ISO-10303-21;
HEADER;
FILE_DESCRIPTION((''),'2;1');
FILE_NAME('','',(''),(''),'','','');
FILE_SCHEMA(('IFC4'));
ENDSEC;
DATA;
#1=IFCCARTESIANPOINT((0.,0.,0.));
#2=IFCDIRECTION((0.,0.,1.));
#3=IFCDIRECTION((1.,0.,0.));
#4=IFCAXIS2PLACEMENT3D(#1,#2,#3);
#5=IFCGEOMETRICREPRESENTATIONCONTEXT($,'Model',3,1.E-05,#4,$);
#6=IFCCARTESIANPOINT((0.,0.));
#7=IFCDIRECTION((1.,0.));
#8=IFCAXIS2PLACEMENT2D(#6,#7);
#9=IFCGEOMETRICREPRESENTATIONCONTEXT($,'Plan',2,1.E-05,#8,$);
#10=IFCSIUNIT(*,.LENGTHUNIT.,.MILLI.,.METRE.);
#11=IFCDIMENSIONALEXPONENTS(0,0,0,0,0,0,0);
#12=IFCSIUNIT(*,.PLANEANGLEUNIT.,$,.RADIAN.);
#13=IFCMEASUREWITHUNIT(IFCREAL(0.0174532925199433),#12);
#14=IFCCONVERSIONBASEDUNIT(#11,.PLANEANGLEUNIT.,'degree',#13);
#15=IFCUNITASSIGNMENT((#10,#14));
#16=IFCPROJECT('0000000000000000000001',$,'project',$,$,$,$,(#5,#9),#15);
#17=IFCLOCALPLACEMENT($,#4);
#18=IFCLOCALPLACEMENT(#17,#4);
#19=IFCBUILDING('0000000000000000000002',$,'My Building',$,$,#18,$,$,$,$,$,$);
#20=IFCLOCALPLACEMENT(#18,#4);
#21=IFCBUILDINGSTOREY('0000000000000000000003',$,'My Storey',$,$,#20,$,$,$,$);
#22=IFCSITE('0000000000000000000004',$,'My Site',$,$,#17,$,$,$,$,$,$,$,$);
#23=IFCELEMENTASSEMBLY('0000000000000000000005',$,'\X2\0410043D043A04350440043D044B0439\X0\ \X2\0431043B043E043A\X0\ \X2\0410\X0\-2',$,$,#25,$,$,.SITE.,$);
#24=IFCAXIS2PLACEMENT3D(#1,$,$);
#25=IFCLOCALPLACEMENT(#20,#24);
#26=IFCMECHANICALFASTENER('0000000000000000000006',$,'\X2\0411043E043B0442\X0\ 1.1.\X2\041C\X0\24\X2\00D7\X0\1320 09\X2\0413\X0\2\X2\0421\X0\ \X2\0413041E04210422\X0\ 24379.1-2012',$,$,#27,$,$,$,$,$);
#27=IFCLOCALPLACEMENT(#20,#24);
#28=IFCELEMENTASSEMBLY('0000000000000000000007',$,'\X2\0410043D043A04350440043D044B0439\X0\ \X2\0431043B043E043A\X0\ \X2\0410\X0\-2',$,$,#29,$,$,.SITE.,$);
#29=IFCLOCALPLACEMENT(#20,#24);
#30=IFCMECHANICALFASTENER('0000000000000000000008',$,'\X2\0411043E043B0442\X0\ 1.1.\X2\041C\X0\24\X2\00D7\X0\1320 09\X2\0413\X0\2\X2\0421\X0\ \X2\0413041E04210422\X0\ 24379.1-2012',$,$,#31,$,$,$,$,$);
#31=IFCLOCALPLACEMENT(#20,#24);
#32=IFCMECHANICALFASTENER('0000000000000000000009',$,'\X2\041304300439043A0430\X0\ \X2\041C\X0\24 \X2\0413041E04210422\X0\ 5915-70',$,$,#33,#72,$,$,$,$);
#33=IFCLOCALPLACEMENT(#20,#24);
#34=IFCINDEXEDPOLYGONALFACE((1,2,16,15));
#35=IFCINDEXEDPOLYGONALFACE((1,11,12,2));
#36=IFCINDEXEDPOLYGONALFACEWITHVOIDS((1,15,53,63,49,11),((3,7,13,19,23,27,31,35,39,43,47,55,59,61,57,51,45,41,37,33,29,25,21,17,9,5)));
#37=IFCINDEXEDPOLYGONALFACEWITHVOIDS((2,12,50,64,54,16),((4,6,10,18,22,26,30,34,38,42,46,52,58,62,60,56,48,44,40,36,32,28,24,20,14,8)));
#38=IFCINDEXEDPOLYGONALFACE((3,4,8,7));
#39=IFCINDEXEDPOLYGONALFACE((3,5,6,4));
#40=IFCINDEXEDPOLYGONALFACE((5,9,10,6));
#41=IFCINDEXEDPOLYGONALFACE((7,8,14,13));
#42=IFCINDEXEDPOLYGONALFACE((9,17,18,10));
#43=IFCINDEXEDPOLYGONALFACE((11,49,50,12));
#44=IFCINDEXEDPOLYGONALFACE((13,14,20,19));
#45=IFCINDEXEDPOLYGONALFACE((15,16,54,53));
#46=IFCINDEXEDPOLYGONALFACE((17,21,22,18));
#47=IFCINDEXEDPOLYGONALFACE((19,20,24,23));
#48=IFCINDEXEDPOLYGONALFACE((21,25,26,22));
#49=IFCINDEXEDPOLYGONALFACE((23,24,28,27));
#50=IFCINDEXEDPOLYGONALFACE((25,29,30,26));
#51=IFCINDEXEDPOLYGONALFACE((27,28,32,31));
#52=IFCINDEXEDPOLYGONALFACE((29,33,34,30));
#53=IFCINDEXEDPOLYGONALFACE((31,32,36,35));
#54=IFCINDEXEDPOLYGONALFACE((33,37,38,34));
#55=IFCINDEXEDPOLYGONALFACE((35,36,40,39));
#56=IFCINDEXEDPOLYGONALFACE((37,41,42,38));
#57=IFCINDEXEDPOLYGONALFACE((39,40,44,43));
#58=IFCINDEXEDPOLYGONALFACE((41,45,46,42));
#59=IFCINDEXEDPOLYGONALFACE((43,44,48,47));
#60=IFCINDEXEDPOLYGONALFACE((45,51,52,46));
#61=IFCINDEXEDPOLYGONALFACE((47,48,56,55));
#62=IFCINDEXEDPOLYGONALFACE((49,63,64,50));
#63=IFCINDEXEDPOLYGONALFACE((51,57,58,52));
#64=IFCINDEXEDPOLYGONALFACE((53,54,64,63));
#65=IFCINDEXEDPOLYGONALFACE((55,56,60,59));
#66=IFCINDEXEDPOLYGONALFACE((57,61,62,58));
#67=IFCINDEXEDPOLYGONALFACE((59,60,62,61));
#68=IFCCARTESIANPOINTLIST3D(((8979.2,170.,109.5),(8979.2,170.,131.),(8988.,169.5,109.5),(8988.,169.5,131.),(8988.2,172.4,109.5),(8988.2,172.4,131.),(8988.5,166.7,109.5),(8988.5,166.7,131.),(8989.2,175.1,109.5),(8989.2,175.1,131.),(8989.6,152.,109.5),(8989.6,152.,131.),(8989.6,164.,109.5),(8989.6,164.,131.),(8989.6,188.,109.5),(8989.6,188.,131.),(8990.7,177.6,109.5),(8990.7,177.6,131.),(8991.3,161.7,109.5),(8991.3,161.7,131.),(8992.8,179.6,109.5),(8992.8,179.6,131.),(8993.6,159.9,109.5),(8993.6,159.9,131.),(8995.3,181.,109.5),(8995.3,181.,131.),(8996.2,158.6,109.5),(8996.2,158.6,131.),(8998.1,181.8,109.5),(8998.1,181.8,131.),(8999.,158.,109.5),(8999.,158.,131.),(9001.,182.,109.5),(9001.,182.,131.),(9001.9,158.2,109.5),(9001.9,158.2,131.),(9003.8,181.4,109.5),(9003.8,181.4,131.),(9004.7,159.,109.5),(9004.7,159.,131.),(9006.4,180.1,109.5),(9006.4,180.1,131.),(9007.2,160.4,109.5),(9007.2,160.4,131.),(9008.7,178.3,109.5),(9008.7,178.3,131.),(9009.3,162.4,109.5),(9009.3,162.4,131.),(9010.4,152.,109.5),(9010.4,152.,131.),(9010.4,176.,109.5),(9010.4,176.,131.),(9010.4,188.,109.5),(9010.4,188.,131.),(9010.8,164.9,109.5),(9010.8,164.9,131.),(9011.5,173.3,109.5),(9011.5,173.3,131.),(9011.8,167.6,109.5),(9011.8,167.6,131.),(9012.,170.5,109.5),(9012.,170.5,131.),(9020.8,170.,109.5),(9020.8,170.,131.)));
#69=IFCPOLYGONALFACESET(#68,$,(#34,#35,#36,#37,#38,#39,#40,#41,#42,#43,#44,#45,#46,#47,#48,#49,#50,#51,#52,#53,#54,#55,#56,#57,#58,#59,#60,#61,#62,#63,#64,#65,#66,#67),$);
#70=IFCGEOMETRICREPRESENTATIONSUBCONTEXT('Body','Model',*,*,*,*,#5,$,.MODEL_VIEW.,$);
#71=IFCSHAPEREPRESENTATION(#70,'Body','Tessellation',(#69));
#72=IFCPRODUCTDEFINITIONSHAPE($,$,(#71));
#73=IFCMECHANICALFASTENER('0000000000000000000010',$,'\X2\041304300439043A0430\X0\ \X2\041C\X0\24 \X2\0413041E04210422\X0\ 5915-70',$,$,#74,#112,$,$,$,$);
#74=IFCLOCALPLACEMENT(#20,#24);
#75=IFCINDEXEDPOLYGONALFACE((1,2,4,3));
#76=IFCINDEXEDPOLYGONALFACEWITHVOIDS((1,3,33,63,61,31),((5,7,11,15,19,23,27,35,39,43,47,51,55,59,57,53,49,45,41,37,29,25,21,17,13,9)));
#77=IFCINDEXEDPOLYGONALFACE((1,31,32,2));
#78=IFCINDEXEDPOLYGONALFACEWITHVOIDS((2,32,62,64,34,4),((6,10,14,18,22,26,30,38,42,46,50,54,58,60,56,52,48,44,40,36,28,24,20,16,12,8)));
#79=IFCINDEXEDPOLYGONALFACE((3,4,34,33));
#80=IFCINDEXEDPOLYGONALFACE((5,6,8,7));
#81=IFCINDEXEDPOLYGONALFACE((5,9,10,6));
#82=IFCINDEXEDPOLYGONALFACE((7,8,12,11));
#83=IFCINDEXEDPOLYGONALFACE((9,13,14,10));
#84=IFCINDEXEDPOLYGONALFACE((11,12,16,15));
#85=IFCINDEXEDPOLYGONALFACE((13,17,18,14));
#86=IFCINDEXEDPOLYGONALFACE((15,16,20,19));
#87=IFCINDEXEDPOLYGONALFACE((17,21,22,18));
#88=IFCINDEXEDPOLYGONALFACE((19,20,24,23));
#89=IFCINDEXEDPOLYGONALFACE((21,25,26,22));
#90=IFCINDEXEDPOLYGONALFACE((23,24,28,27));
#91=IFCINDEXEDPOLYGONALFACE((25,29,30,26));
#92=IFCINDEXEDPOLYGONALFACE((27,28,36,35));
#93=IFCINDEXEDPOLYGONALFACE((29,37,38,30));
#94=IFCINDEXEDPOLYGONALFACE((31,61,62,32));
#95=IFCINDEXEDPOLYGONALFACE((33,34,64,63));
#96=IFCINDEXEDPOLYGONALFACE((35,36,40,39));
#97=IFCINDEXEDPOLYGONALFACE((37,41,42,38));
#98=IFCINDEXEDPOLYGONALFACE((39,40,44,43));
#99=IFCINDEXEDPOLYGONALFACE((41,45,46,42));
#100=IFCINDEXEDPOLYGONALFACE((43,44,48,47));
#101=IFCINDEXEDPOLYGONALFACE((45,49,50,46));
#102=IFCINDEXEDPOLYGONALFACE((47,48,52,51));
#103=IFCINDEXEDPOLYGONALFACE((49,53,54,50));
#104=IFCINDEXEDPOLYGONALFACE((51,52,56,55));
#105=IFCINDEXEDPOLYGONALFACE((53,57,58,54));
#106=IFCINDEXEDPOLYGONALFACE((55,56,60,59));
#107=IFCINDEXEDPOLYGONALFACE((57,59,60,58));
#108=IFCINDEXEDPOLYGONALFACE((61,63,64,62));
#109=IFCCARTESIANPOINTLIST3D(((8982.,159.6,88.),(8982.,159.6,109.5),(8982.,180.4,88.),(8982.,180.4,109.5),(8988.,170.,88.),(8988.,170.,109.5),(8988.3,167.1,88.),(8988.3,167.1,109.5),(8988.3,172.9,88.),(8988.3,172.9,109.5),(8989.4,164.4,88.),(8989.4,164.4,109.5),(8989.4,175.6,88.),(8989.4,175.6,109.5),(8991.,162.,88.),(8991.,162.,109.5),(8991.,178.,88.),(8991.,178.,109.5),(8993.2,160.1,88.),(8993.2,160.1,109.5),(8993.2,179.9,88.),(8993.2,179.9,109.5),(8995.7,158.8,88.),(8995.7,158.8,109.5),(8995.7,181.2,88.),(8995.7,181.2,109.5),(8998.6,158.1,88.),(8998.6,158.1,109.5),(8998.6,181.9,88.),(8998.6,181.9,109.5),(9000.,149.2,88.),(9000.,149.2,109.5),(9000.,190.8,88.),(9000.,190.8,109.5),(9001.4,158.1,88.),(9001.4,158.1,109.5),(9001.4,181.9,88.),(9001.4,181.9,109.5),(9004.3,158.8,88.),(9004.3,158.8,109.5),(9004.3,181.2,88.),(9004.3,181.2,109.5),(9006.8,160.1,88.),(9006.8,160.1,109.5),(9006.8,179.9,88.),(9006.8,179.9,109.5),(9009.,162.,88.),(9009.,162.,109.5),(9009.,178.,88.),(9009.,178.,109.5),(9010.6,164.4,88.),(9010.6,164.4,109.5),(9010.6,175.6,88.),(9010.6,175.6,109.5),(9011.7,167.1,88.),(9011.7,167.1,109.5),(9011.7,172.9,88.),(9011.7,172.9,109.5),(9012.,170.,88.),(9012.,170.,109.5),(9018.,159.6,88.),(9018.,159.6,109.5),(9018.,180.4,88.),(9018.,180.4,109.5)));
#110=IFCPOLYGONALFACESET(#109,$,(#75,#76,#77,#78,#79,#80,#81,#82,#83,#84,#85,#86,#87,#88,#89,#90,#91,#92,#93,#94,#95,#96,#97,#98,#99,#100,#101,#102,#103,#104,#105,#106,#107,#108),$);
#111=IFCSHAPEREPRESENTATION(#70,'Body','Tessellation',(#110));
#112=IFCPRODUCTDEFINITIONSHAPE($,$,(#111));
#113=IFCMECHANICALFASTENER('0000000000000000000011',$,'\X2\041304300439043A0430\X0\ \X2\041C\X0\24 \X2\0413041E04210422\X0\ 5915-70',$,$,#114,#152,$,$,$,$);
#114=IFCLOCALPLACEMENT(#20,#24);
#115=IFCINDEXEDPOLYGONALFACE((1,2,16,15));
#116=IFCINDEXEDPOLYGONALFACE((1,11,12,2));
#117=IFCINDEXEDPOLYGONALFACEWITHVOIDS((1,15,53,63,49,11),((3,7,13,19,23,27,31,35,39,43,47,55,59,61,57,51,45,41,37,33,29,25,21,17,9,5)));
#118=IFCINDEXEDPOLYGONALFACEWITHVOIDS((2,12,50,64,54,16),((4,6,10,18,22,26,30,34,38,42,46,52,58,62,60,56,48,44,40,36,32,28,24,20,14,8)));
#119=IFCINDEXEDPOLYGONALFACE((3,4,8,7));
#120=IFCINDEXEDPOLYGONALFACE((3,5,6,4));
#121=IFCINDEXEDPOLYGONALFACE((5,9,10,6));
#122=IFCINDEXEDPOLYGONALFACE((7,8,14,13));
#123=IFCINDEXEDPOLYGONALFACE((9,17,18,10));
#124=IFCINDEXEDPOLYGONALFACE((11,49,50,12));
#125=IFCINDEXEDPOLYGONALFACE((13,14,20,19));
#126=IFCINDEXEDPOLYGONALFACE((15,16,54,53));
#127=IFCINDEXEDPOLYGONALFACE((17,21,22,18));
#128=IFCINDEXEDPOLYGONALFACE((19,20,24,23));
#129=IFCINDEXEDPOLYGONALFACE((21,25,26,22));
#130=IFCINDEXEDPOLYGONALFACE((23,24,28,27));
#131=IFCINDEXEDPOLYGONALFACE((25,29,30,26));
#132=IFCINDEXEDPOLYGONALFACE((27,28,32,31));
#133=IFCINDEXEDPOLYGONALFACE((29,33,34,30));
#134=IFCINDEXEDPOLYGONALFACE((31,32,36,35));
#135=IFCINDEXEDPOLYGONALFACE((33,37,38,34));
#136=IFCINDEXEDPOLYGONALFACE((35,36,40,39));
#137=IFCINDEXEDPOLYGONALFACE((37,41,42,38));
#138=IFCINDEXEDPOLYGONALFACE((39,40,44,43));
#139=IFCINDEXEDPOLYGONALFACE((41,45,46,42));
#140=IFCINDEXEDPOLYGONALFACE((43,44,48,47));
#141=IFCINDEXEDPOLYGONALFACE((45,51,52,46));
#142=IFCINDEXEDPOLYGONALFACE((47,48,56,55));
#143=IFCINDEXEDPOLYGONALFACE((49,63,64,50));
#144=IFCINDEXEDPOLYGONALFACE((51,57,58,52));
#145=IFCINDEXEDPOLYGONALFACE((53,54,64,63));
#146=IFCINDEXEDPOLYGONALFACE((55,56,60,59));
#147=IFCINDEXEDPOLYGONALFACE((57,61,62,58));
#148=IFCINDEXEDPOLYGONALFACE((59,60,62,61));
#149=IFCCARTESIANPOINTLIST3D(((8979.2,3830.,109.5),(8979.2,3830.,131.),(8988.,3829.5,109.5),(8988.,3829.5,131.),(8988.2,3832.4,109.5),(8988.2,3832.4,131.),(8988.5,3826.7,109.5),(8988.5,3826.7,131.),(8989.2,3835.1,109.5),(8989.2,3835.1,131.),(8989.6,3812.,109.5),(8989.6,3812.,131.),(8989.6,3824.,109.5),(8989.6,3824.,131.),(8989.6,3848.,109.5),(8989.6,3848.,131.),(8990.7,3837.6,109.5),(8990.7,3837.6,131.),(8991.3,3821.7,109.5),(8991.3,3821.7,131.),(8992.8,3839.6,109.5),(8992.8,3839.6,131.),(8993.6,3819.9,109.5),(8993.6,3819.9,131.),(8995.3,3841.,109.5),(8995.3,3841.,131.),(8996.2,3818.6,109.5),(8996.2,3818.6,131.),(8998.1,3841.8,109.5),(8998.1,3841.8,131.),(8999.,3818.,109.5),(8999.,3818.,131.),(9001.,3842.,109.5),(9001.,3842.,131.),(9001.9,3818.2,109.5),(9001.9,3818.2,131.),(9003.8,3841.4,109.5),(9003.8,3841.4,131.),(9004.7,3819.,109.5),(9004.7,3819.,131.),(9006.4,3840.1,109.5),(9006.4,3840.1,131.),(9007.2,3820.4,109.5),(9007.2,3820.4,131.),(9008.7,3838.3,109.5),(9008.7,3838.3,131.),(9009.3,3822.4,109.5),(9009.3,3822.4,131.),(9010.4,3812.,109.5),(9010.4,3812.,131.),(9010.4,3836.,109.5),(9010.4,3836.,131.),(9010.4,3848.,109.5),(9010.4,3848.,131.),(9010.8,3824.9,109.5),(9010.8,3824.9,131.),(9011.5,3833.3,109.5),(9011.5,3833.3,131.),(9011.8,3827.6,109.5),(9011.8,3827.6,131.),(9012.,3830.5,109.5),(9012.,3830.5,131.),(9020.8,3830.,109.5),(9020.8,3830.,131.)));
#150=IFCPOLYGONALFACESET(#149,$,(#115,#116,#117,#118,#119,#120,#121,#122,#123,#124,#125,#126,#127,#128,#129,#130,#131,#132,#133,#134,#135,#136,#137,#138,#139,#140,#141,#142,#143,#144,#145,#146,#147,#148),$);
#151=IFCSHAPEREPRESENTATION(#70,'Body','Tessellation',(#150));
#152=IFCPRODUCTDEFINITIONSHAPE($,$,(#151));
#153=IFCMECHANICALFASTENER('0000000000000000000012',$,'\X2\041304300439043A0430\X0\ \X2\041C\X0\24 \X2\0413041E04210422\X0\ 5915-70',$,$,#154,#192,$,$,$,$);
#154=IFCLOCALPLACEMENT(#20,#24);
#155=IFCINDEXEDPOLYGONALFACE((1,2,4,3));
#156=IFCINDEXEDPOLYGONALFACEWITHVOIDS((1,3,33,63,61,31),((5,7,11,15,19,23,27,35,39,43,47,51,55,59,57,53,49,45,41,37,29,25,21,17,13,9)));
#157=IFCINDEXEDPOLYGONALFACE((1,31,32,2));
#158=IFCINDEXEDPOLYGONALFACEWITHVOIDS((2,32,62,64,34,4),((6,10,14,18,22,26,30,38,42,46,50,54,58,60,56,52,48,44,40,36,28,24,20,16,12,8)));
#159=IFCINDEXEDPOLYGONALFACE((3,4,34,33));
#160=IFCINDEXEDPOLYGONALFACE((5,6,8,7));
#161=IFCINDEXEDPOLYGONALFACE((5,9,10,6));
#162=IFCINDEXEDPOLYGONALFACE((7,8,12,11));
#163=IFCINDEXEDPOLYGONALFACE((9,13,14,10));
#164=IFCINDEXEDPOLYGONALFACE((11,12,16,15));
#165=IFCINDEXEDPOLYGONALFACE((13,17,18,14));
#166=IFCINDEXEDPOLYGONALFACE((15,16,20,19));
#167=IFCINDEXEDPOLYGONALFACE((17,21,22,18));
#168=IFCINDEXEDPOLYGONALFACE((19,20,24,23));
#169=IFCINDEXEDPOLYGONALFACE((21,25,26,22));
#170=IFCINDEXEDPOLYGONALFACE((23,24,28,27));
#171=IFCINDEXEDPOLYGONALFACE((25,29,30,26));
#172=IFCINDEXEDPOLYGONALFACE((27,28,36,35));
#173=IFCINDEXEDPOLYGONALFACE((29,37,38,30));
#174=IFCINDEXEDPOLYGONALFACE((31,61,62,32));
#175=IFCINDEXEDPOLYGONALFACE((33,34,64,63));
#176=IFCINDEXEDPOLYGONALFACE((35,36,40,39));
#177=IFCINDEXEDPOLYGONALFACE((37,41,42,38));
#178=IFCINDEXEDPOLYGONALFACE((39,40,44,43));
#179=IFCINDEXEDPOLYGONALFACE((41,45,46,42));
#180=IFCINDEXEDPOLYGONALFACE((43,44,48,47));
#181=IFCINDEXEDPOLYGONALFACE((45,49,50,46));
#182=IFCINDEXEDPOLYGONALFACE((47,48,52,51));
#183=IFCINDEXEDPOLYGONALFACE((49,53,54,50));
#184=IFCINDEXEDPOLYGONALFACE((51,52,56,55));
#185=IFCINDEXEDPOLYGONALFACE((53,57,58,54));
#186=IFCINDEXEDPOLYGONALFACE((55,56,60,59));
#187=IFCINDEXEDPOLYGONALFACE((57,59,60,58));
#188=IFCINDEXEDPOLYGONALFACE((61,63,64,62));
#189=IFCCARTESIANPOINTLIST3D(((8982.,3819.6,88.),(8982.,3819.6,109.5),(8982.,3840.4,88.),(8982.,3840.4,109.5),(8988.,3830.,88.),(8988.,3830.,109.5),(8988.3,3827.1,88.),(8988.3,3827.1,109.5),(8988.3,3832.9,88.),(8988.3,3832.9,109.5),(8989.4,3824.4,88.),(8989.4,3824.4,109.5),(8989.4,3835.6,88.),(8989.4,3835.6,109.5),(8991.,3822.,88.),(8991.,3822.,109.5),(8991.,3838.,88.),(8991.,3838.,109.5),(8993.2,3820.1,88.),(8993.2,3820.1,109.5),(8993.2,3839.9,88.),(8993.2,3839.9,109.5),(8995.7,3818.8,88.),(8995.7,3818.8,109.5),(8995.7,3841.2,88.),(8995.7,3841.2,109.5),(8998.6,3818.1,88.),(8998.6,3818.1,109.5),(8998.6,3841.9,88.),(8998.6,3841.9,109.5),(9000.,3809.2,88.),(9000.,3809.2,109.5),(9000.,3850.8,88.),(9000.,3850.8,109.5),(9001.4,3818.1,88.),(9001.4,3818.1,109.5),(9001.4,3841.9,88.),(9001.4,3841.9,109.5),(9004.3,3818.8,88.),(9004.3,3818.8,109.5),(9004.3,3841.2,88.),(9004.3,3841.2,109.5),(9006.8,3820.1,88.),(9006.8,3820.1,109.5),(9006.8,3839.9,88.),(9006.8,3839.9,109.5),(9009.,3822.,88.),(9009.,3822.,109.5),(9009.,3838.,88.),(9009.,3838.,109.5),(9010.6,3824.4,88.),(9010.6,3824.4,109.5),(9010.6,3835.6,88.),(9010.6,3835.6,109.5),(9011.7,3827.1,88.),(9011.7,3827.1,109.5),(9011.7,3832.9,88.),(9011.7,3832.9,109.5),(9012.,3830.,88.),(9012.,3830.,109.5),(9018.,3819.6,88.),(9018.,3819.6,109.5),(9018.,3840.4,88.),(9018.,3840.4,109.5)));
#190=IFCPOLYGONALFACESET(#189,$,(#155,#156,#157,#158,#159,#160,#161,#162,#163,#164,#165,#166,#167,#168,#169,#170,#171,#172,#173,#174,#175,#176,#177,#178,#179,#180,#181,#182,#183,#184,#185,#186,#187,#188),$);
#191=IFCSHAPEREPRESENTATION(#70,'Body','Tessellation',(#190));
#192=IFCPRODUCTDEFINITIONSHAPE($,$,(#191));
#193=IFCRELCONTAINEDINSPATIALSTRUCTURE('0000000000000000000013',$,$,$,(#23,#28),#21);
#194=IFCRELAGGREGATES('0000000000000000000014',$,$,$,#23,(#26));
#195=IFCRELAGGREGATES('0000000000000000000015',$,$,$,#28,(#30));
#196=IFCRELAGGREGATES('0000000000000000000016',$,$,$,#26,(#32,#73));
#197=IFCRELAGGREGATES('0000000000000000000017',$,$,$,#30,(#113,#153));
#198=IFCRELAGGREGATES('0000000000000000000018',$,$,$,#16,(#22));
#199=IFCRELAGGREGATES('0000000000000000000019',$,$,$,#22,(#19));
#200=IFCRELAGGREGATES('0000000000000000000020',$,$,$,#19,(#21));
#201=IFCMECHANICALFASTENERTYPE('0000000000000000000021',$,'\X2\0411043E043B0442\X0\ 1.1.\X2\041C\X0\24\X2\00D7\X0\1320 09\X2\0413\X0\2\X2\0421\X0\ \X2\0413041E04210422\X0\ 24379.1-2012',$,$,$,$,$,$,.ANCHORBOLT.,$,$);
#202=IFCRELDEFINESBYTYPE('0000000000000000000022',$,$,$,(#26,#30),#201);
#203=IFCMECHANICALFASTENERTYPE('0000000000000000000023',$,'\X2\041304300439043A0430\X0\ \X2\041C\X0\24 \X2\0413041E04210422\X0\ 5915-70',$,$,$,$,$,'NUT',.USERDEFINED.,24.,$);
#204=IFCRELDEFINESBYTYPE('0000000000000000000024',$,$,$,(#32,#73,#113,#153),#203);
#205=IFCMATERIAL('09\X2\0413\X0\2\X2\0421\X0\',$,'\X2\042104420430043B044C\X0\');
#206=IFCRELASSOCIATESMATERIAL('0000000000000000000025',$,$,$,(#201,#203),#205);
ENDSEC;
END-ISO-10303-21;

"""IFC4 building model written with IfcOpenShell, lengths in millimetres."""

from ifc_helpers import new_model, entity, si_unit, converted_unit, frame, origin_with_axes, origin_2d_with_axis, place, context, subcontext, project, spatial, polyline, outline, extrude, source, transform, mapped, material, type_object, type_shapes, element, aggregate, save


model = new_model("IFC4")

# Units and contexts
model_context = context("Model", 3, precision=1e-05, world=origin_with_axes())
plan_context = context("Plan", 2, precision=1e-05, world=origin_2d_with_axis())
body_context = subcontext(model_context, "Body", "Model", "MODEL_VIEW")
ifc_project = project(units=[si_unit("LENGTHUNIT", "METRE", prefix="MILLI"), converted_unit("PLANEANGLEUNIT", "degree", entity("IfcReal", 0.0174532925199433), si_unit("PLANEANGLEUNIT", "RADIAN"), dimensions=[0, 0, 0, 0, 0, 0, 0])], contexts=[model_context, plan_context])

# Site, building, storey
site_placement = place(None, origin_with_axes())
site = spatial("IfcSite", under=ifc_project, at=site_placement, Name="My Site")
building_placement = place(site_placement, origin_with_axes())
building = spatial("IfcBuilding", under=site, at=building_placement, Name="My Building")
storey_placement = place(building_placement, origin_with_axes())
storey = spatial("IfcBuildingStorey", under=building, at=storey_placement, Name="My Storey")

# Element assemblies, mechanical fasteners
ifc_material_1 = material(Name="09Г2С", Category="Сталь")
mechanical_fastener_type_1 = type_object("IfcMechanicalFastenerType", Name="Болт 1.1.М24×1320 09Г2С ГОСТ 24379.1-2012", PredefinedType="ANCHORBOLT", material=ifc_material_1)
assembly_1_placement = place(storey_placement, frame((9000.0, 0.0, 0.0), z_axis=(0.0, 0.0, 1.0), x_axis=(1.0, 0.0, 0.0)))
assembly_1 = element("IfcElementAssembly", 1, at=assembly_1_placement, inside=storey, Name="Анкерный блок А-2", AssemblyPlace="SITE")
mechanical_fastener_1_placement = place(assembly_1_placement, frame((0.0, 170.0, 0.0), z_axis=(0.0, 0.0, 1.0), x_axis=(-1.0, 0.0, 0.0)))
mechanical_fastener_1 = element("IfcMechanicalFastener", 2, at=mechanical_fastener_1_placement, type_object=mechanical_fastener_type_1, Name="Болт 1.1.М24×1320 09Г2С ГОСТ 24379.1-2012")
aggregate(assembly_1, [mechanical_fastener_1])
assembly_2_placement = place(storey_placement, frame((9000.0, 4000.0, 0.0), z_axis=(0.0, 0.0, 1.0), x_axis=(1.0, 0.0, 0.0)))
assembly_2 = element("IfcElementAssembly", 3, at=assembly_2_placement, inside=storey, Name="Анкерный блок А-2", AssemblyPlace="SITE")
mechanical_fastener_2_placement = place(assembly_2_placement, frame((0.0, -170.0, 0.0), z_axis=(0.0, 0.0, 1.0), x_axis=(1.0, 0.0, 0.0)))
mechanical_fastener_2 = element("IfcMechanicalFastener", 4, at=mechanical_fastener_2_placement, type_object=mechanical_fastener_type_1, Name="Болт 1.1.М24×1320 09Г2С ГОСТ 24379.1-2012")
aggregate(assembly_2, [mechanical_fastener_2])
mechanical_fastener_type_2 = type_object("IfcMechanicalFastenerType", Name="Гайка М24 ГОСТ 5915-70", ElementType="NUT", NominalDiameter=24.0, PredefinedType="USERDEFINED", material=ifc_material_1)
shared_shape_1 = source(origin_with_axes(), body_context, "Body", "SweptSolid", [
    extrude(outline(polyline([(-10.4, -18.0), (10.4, -18.0), (20.8, 0.0), (10.4, 18.0), (-10.4, 18.0), (-20.8, 0.0), (-10.4, -18.0)]), holes=[polyline([(-8.0, 9.0), (-5.6, 10.6), (-2.9, 11.7), (0.0, 12.0), (2.9, 11.7), (5.6, 10.6), (8.0, 9.0), (9.9, 6.8), (11.2, 4.3), (11.9, 1.4), (11.9, -1.4), (11.2, -4.3), (9.9, -6.8), (8.0, -9.0), (5.6, -10.6), (2.9, -11.7), (0.0, -12.0), (-2.9, -11.7), (-5.6, -10.6), (-8.0, -9.0), (-9.9, -6.8), (-11.2, -4.3), (-11.9, -1.4), (-11.9, 1.4), (-11.2, 4.3), (-9.9, 6.8), (-8.0, 9.0)])]), frame((0.0, 0.0, 0.0), z_axis=(0.0, 0.0, 1.0), x_axis=(0.0, 1.0, 0.0)), (0.0, 0.0, 1.0), 21.5),
])
type_shapes(mechanical_fastener_type_2, [shared_shape_1])

# Mechanical fasteners
mechanical_fastener_3_placement = place(mechanical_fastener_1_placement, frame((0.0, 0.0, 109.5), z_axis=(0.0, 0.0, 1.0), x_axis=(0.866025, 0.5, 0.0)))
mechanical_fastener_3 = element("IfcMechanicalFastener", 5, at=mechanical_fastener_3_placement, type_object=mechanical_fastener_type_2, Name="Гайка М24 ГОСТ 5915-70", context=body_context, shape_type="MappedRepresentation", body=[
    mapped(shared_shape_1, transform((0.0, 0.0, 0.0), x_axis=(1.0, 0.0, 0.0), y_axis=(0.0, 1.0, 0.0), z_axis=(0.0, 0.0, 1.0), scale=1.0)),
])
mechanical_fastener_4_placement = place(mechanical_fastener_1_placement, frame((0.0, 0.0, 88.0), z_axis=(0.0, 0.0, 1.0), x_axis=(1.0, 0.0, 0.0)))
mechanical_fastener_4 = element("IfcMechanicalFastener", 6, at=mechanical_fastener_4_placement, type_object=mechanical_fastener_type_2, Name="Гайка М24 ГОСТ 5915-70", context=body_context, shape_type="MappedRepresentation", body=[
    mapped(shared_shape_1, transform((0.0, 0.0, 0.0), x_axis=(1.0, 0.0, 0.0), y_axis=(0.0, 1.0, 0.0), z_axis=(0.0, 0.0, 1.0), scale=1.0)),
])
mechanical_fastener_5_placement = place(mechanical_fastener_2_placement, frame((0.0, 0.0, 109.5), z_axis=(0.0, 0.0, 1.0), x_axis=(0.866025, 0.5, 0.0)))
mechanical_fastener_5 = element("IfcMechanicalFastener", 7, at=mechanical_fastener_5_placement, type_object=mechanical_fastener_type_2, Name="Гайка М24 ГОСТ 5915-70", context=body_context, shape_type="MappedRepresentation", body=[
    mapped(shared_shape_1, transform((0.0, 0.0, 0.0), x_axis=(1.0, 0.0, 0.0), y_axis=(0.0, 1.0, 0.0), z_axis=(0.0, 0.0, 1.0), scale=1.0)),
])
mechanical_fastener_6_placement = place(mechanical_fastener_2_placement, frame((0.0, 0.0, 88.0), z_axis=(0.0, 0.0, 1.0), x_axis=(1.0, 0.0, 0.0)))
mechanical_fastener_6 = element("IfcMechanicalFastener", 8, at=mechanical_fastener_6_placement, type_object=mechanical_fastener_type_2, Name="Гайка М24 ГОСТ 5915-70", context=body_context, shape_type="MappedRepresentation", body=[
    mapped(shared_shape_1, transform((0.0, 0.0, 0.0), x_axis=(1.0, 0.0, 0.0), y_axis=(0.0, 1.0, 0.0), z_axis=(0.0, 0.0, 1.0), scale=1.0)),
])
aggregate(mechanical_fastener_1, [mechanical_fastener_3, mechanical_fastener_4])
aggregate(mechanical_fastener_2, [mechanical_fastener_5, mechanical_fastener_6])

save(model, "model.ifc")
